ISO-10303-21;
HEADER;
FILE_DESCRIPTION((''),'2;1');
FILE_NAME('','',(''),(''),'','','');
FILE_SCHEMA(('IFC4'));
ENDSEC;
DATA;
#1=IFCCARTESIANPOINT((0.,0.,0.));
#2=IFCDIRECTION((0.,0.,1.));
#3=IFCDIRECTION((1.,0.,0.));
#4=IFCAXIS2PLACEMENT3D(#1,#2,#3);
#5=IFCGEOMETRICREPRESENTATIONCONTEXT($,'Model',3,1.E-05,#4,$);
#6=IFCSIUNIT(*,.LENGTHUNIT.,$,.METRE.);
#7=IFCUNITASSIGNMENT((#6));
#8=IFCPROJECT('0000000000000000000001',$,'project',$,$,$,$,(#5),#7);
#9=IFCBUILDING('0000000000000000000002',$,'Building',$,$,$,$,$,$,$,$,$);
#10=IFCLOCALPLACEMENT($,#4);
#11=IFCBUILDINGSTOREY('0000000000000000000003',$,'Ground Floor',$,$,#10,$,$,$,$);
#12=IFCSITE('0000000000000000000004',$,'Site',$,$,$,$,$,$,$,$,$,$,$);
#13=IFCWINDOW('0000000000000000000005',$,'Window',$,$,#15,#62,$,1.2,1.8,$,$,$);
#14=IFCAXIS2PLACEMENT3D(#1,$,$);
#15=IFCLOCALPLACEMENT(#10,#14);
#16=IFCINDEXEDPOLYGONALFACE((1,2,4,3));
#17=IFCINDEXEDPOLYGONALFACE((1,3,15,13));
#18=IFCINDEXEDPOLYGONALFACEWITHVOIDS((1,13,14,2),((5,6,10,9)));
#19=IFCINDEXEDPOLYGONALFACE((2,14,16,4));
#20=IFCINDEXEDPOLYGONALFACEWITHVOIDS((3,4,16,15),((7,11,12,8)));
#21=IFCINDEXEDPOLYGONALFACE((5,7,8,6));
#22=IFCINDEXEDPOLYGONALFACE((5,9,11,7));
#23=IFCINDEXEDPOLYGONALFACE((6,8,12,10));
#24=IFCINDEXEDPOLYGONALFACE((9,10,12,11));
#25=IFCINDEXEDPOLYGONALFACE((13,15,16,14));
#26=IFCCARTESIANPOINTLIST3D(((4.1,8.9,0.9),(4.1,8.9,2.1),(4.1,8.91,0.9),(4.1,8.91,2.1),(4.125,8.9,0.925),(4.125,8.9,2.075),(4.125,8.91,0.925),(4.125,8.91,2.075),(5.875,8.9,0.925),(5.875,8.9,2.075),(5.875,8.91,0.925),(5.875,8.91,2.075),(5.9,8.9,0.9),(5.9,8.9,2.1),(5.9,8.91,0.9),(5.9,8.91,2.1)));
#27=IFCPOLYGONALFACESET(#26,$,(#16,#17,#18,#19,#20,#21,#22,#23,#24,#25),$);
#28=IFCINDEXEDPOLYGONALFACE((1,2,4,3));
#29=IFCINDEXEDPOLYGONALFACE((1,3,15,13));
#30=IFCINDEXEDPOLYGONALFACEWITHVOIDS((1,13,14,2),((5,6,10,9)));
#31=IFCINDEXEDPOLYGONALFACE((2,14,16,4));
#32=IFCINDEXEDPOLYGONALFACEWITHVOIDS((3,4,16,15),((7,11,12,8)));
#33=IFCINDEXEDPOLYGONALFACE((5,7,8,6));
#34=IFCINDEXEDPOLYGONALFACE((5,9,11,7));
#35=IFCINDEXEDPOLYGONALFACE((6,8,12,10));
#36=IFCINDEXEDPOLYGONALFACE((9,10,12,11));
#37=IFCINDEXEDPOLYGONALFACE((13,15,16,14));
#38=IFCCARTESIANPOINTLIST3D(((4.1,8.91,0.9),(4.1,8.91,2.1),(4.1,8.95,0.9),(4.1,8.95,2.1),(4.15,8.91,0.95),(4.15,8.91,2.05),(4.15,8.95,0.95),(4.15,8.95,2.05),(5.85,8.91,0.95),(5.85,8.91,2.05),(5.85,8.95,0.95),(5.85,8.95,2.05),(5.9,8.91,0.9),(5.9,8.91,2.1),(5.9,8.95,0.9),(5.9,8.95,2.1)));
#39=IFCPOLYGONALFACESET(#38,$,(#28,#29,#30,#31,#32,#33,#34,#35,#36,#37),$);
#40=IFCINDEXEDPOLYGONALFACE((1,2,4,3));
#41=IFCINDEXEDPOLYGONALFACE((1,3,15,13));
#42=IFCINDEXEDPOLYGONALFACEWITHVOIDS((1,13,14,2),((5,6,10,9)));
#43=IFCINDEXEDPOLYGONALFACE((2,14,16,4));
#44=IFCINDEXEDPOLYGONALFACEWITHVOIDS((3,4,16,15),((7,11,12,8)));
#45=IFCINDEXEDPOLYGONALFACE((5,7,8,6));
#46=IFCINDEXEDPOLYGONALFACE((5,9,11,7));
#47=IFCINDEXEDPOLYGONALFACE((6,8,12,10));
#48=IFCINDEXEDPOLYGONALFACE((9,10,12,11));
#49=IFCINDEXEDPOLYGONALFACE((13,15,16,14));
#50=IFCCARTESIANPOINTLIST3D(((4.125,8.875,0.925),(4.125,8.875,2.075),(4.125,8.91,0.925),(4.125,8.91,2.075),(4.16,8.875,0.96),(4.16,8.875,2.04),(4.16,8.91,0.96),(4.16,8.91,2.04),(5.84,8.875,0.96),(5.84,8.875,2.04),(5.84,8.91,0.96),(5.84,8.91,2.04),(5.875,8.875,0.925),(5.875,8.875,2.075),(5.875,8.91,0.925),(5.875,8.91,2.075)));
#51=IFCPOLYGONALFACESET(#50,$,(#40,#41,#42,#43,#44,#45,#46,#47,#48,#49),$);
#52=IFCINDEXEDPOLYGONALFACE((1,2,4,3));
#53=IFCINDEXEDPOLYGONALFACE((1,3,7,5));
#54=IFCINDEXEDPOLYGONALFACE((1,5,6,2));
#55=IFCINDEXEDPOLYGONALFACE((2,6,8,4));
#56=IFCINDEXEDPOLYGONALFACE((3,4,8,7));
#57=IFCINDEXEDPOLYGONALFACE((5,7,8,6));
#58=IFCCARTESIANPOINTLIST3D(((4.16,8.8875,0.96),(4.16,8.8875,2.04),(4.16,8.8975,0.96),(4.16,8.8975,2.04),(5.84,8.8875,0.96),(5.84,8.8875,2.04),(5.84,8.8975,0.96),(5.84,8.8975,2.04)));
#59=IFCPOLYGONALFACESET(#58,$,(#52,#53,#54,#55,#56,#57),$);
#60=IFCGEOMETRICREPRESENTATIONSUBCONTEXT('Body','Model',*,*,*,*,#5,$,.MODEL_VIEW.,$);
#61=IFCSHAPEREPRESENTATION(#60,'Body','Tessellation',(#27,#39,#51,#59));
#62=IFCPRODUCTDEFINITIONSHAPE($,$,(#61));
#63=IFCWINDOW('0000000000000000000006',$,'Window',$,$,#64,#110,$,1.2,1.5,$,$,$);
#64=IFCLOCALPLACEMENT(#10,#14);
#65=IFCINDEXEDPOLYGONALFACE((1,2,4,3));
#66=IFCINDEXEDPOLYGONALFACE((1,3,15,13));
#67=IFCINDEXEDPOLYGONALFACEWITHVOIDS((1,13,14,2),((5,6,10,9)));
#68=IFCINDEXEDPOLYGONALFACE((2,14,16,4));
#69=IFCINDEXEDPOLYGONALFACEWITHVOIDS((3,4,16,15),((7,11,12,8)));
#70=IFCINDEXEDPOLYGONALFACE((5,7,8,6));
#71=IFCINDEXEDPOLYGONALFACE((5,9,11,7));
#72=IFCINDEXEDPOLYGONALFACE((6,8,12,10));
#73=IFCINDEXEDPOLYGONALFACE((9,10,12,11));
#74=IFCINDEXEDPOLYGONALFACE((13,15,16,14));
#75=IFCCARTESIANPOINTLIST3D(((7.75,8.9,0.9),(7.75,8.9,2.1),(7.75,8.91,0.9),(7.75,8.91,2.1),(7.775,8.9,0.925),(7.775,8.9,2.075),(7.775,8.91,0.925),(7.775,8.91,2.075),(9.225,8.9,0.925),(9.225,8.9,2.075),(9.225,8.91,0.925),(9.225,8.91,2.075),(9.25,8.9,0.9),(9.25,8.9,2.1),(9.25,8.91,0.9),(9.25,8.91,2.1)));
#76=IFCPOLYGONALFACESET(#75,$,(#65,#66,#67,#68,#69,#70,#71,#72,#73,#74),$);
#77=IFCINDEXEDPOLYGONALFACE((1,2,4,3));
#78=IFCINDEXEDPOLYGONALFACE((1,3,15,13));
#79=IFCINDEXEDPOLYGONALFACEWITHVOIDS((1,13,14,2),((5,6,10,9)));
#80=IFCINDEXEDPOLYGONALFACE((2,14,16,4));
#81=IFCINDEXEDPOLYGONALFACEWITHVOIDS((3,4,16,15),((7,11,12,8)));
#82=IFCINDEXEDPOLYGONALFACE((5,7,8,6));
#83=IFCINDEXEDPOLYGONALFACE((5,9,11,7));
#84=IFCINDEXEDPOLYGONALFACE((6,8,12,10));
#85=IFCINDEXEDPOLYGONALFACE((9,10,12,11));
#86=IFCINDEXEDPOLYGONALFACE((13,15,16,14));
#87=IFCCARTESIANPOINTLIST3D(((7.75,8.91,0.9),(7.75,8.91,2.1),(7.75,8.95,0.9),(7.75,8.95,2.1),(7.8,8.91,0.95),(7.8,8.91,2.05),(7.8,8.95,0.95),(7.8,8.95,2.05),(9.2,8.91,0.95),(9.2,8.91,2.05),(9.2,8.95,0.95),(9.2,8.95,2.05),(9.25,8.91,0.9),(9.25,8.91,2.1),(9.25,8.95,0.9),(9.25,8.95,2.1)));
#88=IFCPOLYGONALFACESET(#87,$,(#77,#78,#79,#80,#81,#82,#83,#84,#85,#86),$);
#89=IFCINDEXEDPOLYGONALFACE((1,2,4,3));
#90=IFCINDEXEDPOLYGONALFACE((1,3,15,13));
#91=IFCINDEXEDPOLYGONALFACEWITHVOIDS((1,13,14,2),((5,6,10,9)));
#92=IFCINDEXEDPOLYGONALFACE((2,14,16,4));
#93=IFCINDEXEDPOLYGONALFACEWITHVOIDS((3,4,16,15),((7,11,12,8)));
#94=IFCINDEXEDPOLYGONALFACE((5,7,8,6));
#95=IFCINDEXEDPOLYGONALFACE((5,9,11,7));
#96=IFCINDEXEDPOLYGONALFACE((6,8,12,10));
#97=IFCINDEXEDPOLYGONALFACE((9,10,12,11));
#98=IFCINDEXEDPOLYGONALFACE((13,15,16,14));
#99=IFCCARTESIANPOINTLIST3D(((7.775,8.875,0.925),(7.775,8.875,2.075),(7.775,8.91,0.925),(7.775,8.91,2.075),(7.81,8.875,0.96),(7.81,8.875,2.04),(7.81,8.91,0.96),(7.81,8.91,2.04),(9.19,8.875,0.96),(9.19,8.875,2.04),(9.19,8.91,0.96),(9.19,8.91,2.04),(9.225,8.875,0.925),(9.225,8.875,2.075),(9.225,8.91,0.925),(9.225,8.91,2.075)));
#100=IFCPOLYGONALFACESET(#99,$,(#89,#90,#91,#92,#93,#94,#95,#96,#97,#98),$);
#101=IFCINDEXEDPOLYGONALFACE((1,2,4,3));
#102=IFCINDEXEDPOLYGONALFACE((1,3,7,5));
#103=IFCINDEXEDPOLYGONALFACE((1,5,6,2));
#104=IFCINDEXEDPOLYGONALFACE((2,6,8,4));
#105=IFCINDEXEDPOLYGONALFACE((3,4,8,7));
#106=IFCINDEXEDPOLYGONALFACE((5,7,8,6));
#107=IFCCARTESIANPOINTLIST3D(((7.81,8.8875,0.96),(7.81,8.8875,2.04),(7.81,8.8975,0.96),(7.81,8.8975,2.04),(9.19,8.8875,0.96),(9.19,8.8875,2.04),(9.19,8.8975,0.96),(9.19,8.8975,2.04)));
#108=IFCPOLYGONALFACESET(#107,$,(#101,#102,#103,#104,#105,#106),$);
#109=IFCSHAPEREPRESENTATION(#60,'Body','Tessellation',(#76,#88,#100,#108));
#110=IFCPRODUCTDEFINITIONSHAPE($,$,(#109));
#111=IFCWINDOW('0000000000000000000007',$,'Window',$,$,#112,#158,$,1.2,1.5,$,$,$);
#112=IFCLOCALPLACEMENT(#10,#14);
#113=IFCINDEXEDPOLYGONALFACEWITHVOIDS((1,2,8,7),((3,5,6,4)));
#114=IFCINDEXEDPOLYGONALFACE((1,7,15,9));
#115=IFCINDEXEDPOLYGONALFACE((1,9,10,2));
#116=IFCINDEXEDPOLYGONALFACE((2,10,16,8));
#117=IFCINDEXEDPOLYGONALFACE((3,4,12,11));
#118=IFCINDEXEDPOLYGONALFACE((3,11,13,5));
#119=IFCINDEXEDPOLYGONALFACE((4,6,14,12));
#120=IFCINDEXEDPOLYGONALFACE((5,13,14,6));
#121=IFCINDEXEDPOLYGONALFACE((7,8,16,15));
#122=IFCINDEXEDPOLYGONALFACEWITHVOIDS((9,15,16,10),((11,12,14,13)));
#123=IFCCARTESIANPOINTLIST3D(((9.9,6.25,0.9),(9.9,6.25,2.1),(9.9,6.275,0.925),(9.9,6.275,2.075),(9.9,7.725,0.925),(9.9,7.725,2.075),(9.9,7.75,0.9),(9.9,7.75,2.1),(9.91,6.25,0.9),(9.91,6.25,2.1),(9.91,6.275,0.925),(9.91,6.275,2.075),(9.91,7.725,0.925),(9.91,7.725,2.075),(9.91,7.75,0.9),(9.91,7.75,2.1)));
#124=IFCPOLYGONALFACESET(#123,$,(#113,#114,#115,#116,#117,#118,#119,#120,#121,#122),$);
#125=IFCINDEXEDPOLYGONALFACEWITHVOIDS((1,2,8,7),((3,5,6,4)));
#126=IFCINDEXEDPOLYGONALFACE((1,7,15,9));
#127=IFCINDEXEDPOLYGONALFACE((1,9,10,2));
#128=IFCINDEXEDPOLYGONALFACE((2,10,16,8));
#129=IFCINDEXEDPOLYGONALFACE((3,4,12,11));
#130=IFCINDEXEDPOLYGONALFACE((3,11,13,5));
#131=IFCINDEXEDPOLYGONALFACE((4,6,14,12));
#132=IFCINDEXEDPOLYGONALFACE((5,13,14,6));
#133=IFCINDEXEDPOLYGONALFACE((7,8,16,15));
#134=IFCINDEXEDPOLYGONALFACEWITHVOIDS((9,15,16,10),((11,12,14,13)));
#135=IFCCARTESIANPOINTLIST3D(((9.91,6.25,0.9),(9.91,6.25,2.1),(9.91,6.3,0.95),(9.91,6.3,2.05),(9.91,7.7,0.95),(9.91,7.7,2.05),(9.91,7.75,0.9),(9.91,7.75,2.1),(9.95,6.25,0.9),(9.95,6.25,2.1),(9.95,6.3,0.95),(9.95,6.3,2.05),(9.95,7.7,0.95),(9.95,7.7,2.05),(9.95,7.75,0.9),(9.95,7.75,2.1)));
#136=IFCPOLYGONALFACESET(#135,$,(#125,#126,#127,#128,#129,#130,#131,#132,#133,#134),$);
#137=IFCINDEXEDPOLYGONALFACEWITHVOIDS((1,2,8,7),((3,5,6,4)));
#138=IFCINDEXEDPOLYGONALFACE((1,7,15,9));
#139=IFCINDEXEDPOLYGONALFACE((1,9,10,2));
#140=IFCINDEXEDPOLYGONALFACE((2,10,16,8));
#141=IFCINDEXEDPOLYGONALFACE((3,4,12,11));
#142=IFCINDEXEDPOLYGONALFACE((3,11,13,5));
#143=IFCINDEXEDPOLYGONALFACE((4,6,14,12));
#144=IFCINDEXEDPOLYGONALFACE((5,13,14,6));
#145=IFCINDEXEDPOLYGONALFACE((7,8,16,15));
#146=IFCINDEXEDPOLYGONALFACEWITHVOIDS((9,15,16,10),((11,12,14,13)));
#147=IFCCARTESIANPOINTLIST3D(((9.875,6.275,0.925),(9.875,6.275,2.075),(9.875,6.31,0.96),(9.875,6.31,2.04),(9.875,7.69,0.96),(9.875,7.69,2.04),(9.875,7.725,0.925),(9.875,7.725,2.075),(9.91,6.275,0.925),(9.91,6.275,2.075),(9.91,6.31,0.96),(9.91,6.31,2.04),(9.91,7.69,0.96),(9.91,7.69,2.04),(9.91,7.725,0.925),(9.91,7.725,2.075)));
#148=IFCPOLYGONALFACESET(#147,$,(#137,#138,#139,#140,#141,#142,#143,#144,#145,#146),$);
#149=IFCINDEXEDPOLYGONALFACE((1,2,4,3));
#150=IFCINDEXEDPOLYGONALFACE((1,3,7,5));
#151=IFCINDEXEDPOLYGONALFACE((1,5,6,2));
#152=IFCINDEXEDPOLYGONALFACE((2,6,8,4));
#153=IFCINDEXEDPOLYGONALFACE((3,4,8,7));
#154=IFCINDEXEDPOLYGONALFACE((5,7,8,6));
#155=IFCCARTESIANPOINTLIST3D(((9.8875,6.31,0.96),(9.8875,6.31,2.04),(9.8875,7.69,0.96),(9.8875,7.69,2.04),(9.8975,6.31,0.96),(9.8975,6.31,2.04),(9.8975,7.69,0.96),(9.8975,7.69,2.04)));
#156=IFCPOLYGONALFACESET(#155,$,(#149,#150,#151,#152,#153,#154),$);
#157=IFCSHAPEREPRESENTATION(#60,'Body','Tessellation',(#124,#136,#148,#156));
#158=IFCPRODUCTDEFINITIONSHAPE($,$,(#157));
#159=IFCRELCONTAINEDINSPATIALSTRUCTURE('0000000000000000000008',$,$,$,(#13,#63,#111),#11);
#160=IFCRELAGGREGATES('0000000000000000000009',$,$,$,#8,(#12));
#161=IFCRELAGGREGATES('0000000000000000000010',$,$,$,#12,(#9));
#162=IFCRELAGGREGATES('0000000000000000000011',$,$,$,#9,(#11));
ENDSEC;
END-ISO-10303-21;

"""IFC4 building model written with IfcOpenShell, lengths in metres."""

from ifc_helpers import new_model, si_unit, frame, origin_with_axes, place, context, subcontext, project, spatial, line, indexed_curve, outline, extrude, element, save


model = new_model("IFC4")

# Units and contexts
model_context = context("Model", 3, precision=1e-05, world=origin_with_axes())
body_context = subcontext(model_context, "Body", "Model", "MODEL_VIEW")
ifc_project = project(units=[si_unit("LENGTHUNIT", "METRE")], contexts=[model_context])

# Site, building, storey
site = spatial("IfcSite", under=ifc_project, Name="Site")
building = spatial("IfcBuilding", under=site, Name="Building")
storey_placement = place(None, origin_with_axes())
storey = spatial("IfcBuildingStorey", under=building, at=storey_placement, Name="Ground Floor")

# Windows
window_1_placement = place(storey_placement, frame((5.9, 9.0, 0.9), z_axis=(0.0, 0.0, 1.0), x_axis=(-1.0, 0.0, 0.0)))
element("IfcWindow", 1, at=window_1_placement, inside=storey, Name="Window", OverallHeight=1.2, OverallWidth=1.8, context=body_context, shape_type="SweptSolid", body=[
    extrude(outline(indexed_curve([(0.0, 0.0), (1.8, 0.0), (1.8, 1.2), (0.0, 1.2)], segments=[line(1, 2, 3, 4, 1)]), holes=[indexed_curve([(0.025, 0.025), (1.775, 0.025), (1.775, 1.175), (0.025, 1.175)], segments=[line(1, 2, 3, 4, 1)])]), frame((0.0, 0.09, 0.0), z_axis=(0.0, -1.0, 0.0), x_axis=(1.0, 0.0, 0.0)), (0.0, 0.0, -1.0), 0.01),
    extrude(outline(indexed_curve([(0.0, 0.0), (1.8, 0.0), (1.8, 1.2), (0.0, 1.2)], segments=[line(1, 2, 3, 4, 1)]), holes=[indexed_curve([(0.05, 0.05), (1.75, 0.05), (1.75, 1.15), (0.05, 1.15)], segments=[line(1, 2, 3, 4, 1)])]), frame((0.0, 0.05, 0.0), z_axis=(0.0, -1.0, 0.0), x_axis=(1.0, 0.0, 0.0)), (0.0, 0.0, -1.0), 0.04),
    extrude(outline(indexed_curve([(0.0, 0.0), (1.75, 0.0), (1.75, 1.15), (0.0, 1.15)], segments=[line(1, 2, 3, 4, 1)]), holes=[indexed_curve([(0.035, 0.035), (1.715, 0.035), (1.715, 1.115), (0.035, 1.115)], segments=[line(1, 2, 3, 4, 1)])]), frame((0.025, 0.09, 0.025), z_axis=(0.0, -1.0, 0.0), x_axis=(1.0, 0.0, 0.0)), (0.0, 0.0, -1.0), 0.035),
    extrude(outline(indexed_curve([(0.035, 0.035), (1.715, 0.035), (1.715, 1.115), (0.035, 1.115)], segments=[line(1, 2, 3, 4, 1)])), frame((0.025, 0.1025, 0.025), z_axis=(0.0, -1.0, 0.0), x_axis=(1.0, 0.0, 0.0)), (0.0, 0.0, -1.0), 0.01),
])
for number, where, z_axis, x_axis, name in (
    (2, (9.25, 9.0, 0.9), (0.0, 0.0, 1.0), (-1.0, 0.0, 0.0), "Window"),
    (3, (10.0, 6.25, 0.9), (0.0, 0.0, 1.0), (0.0, 1.0, 0.0), "Window"),
):
    element("IfcWindow", number, at=place(storey_placement, frame(where, z_axis=z_axis, x_axis=x_axis)), inside=storey, Name=name, OverallHeight=1.2, OverallWidth=1.5, context=body_context, shape_type="SweptSolid", body=[
        extrude(outline(indexed_curve([(0.0, 0.0), (1.5, 0.0), (1.5, 1.2), (0.0, 1.2)], segments=[line(1, 2, 3, 4, 1)]), holes=[indexed_curve([(0.025, 0.025), (1.475, 0.025), (1.475, 1.175), (0.025, 1.175)], segments=[line(1, 2, 3, 4, 1)])]), frame((0.0, 0.09, 0.0), z_axis=(0.0, -1.0, 0.0), x_axis=(1.0, 0.0, 0.0)), (0.0, 0.0, -1.0), 0.01),
        extrude(outline(indexed_curve([(0.0, 0.0), (1.5, 0.0), (1.5, 1.2), (0.0, 1.2)], segments=[line(1, 2, 3, 4, 1)]), holes=[indexed_curve([(0.05, 0.05), (1.45, 0.05), (1.45, 1.15), (0.05, 1.15)], segments=[line(1, 2, 3, 4, 1)])]), frame((0.0, 0.05, 0.0), z_axis=(0.0, -1.0, 0.0), x_axis=(1.0, 0.0, 0.0)), (0.0, 0.0, -1.0), 0.04),
        extrude(outline(indexed_curve([(0.0, 0.0), (1.45, 0.0), (1.45, 1.15), (0.0, 1.15)], segments=[line(1, 2, 3, 4, 1)]), holes=[indexed_curve([(0.035, 0.035), (1.415, 0.035), (1.415, 1.115), (0.035, 1.115)], segments=[line(1, 2, 3, 4, 1)])]), frame((0.025, 0.09, 0.025), z_axis=(0.0, -1.0, 0.0), x_axis=(1.0, 0.0, 0.0)), (0.0, 0.0, -1.0), 0.035),
        extrude(outline(indexed_curve([(0.035, 0.035), (1.415, 0.035), (1.415, 1.115), (0.035, 1.115)], segments=[line(1, 2, 3, 4, 1)])), frame((0.025, 0.1025, 0.025), z_axis=(0.0, -1.0, 0.0), x_axis=(1.0, 0.0, 0.0)), (0.0, 0.0, -1.0), 0.01),
    ])

save(model, "model.ifc")
